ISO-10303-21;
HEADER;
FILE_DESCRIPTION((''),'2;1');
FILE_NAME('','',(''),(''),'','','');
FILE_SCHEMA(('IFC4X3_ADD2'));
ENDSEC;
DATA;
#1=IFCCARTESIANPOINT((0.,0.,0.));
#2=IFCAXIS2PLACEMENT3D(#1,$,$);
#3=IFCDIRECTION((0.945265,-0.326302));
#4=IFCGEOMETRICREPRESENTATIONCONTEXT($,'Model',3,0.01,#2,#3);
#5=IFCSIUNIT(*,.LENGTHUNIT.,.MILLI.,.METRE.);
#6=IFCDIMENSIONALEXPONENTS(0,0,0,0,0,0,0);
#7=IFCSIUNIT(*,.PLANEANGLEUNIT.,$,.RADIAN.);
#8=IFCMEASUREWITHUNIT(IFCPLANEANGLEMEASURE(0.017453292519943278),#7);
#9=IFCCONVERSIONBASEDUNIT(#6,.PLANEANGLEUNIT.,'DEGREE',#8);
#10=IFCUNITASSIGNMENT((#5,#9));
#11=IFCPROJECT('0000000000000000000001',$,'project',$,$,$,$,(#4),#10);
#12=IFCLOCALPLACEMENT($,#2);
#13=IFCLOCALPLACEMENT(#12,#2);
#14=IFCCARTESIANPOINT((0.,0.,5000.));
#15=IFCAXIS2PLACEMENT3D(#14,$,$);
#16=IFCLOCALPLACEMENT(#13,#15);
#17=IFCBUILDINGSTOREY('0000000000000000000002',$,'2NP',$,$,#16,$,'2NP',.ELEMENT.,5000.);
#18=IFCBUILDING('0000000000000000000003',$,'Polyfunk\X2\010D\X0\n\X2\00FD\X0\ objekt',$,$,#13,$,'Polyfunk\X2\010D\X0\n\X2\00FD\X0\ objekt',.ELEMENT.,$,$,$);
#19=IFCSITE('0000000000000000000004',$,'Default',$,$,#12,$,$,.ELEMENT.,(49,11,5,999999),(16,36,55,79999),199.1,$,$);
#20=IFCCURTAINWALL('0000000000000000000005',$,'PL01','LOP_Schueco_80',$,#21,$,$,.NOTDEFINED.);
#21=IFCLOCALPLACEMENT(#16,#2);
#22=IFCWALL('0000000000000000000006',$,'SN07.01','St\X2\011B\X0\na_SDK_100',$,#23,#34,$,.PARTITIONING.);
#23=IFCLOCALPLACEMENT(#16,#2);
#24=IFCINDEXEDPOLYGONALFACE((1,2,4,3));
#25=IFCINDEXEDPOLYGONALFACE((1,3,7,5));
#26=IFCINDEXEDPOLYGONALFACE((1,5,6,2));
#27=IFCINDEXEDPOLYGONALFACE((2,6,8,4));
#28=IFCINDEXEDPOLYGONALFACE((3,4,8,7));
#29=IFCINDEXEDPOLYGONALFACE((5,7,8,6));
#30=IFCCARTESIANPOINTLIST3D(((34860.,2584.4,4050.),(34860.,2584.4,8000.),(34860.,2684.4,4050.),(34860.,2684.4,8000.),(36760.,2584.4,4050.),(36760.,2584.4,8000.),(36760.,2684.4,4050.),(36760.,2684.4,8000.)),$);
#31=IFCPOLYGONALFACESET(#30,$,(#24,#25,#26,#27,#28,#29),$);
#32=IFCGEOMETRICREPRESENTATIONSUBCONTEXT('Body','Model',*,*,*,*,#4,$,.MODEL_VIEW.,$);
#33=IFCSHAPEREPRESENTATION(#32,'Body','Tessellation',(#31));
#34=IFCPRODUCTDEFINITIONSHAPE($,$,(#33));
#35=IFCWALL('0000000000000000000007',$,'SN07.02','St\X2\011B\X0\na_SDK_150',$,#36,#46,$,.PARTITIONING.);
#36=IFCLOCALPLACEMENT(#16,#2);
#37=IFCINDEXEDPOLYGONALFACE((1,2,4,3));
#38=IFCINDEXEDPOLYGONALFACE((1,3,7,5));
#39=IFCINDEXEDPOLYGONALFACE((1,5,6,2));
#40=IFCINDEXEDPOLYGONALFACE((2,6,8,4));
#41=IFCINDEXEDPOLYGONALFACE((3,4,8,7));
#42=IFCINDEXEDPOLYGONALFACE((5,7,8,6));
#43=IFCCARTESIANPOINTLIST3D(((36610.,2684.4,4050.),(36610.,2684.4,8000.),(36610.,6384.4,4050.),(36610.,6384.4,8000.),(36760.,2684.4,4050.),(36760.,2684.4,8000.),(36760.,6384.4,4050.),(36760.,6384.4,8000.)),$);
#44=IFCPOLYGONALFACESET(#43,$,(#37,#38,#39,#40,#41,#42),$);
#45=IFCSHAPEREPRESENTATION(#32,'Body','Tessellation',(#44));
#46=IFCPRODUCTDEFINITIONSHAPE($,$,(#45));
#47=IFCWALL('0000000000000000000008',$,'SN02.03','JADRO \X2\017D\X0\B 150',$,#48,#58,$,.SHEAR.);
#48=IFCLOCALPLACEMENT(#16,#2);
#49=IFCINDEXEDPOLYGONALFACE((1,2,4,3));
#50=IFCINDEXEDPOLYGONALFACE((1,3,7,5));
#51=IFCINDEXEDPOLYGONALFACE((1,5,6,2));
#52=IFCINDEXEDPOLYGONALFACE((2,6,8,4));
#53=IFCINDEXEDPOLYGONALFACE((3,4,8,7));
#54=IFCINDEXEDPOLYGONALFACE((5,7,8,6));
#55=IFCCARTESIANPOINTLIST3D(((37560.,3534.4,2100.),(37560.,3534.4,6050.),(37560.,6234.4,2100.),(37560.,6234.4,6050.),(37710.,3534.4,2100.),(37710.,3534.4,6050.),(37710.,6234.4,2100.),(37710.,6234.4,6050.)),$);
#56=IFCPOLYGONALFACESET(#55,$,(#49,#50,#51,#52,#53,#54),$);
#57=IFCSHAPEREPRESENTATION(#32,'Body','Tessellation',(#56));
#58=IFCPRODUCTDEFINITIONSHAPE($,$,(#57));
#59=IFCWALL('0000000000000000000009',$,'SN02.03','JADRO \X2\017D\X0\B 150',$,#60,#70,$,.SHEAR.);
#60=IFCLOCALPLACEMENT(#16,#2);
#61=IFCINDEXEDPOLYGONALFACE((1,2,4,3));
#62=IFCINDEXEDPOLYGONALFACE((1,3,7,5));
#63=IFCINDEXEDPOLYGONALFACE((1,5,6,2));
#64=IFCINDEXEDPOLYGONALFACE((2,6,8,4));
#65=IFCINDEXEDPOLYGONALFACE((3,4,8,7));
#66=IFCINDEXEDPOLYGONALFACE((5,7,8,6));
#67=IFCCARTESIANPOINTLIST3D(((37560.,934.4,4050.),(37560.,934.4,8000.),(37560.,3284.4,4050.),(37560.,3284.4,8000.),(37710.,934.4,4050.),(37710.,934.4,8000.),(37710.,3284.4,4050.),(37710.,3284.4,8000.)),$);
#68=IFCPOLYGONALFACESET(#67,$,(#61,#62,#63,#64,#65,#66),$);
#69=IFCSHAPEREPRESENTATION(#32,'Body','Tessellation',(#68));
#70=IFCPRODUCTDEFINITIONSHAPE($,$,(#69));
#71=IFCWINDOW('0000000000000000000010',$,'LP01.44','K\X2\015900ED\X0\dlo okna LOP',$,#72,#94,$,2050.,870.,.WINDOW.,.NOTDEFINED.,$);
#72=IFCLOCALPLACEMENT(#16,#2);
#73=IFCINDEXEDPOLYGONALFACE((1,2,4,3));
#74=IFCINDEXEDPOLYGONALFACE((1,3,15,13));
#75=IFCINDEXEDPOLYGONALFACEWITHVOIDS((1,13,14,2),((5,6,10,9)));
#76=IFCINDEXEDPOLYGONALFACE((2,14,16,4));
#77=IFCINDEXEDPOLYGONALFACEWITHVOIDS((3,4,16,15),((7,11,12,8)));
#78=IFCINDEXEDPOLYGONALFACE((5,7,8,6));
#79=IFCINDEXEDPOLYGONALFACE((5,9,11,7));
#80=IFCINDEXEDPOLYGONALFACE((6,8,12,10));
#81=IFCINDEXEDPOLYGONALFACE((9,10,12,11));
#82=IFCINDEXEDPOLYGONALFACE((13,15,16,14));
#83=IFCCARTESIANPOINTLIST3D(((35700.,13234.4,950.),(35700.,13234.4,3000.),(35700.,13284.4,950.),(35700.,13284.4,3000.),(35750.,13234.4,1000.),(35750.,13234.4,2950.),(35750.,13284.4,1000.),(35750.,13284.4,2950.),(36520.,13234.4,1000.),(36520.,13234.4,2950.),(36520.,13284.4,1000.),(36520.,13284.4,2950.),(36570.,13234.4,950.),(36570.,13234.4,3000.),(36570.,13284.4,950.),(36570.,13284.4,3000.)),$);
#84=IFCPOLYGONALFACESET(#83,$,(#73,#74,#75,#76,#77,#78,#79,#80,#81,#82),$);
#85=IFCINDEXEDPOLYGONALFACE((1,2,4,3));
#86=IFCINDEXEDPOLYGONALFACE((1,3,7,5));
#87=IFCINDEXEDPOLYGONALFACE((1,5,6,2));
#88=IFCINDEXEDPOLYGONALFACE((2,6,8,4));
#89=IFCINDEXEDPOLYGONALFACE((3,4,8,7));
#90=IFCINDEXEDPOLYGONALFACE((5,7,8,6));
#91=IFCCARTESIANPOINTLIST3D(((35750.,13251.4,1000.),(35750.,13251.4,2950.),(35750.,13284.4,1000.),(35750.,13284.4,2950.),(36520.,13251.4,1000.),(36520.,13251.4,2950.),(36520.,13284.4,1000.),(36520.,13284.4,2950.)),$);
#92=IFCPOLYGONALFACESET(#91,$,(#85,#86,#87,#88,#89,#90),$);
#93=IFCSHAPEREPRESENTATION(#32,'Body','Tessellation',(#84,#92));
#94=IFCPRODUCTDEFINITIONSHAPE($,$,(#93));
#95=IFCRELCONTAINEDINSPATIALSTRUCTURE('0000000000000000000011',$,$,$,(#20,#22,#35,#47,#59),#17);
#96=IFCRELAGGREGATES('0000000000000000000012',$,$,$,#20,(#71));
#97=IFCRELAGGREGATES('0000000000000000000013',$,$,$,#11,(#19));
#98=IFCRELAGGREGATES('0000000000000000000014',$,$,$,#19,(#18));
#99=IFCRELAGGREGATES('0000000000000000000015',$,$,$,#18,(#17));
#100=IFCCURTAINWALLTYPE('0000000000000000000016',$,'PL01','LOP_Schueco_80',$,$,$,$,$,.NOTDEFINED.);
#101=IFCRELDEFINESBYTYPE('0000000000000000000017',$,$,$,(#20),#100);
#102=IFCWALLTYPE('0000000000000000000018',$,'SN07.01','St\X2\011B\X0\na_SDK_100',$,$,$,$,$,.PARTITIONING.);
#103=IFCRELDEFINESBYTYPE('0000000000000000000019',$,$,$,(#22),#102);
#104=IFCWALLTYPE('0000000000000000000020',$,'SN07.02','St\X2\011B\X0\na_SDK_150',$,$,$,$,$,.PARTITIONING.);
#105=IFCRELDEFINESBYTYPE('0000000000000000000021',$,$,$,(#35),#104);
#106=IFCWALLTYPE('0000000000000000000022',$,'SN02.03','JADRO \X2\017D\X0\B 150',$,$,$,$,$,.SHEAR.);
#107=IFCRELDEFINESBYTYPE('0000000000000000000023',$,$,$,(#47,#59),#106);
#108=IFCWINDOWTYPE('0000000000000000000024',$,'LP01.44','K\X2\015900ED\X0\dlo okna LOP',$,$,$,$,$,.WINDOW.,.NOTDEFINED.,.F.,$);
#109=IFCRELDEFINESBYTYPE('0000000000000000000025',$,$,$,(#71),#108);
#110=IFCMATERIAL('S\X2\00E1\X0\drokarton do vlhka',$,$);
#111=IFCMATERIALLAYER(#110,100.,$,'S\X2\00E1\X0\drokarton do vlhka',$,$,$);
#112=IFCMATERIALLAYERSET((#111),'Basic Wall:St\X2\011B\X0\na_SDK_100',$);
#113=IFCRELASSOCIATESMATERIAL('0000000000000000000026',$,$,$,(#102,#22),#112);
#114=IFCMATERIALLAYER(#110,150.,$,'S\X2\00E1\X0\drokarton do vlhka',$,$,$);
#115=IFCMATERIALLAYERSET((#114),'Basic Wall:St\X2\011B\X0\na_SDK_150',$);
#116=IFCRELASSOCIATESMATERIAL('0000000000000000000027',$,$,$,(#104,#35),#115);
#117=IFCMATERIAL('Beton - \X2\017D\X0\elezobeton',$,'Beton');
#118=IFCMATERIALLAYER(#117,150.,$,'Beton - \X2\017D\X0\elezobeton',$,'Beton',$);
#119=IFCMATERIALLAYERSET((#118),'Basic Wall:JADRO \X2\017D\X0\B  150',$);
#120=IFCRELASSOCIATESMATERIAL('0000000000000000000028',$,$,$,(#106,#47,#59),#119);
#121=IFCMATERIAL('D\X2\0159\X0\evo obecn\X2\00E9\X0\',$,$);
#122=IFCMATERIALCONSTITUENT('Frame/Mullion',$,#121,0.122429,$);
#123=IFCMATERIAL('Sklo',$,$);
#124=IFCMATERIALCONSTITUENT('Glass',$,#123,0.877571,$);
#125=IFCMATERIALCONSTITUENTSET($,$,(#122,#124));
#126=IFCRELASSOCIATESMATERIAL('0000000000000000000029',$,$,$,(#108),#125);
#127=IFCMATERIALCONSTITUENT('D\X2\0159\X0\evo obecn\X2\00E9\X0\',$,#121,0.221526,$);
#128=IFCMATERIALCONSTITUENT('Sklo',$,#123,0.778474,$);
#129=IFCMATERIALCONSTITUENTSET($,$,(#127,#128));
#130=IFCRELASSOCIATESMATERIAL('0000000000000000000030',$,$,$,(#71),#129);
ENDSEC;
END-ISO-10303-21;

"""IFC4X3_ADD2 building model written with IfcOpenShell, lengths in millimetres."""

from ifc_helpers import new_model, entity, si_unit, converted_unit, direction, frame, frame_2d, origin, origin_2d_with_axis, place, context, subcontext, project, spatial, polyline, rectangle, outline, extrude, clip, bounded_halfspace, source, transform, mapped, material, layer, layer_set, constituent, constituent_set, type_object, type_shapes, element, aggregate, save


model = new_model("IFC4X3_ADD2")

# Units and contexts
model_context = context("Model", 3, precision=0.01, world=origin(), true_north=direction((0.945265, -0.326302)))
body_context = subcontext(model_context, "Body", "Model", "MODEL_VIEW")
ifc_project = project(units=[si_unit("LENGTHUNIT", "METRE", prefix="MILLI"), converted_unit("PLANEANGLEUNIT", "DEGREE", entity("IfcPlaneAngleMeasure", 0.017453292519943278), si_unit("PLANEANGLEUNIT", "RADIAN"), dimensions=[0, 0, 0, 0, 0, 0, 0])], contexts=[model_context])

# Site, building, storey
site_placement = place(None, origin())
site = spatial("IfcSite", under=ifc_project, at=site_placement, Name="Default", CompositionType="ELEMENT", RefLatitude=(49, 11, 5, 999999), RefLongitude=(16, 36, 55, 79999), RefElevation=199.1)
building_placement = place(site_placement, origin())
building = spatial("IfcBuilding", under=site, at=building_placement, Name="Polyfunkčný objekt", LongName="Polyfunkčný objekt", CompositionType="ELEMENT")
storey_placement = place(building_placement, frame((0.0, 0.0, 5000.0)))
storey = spatial("IfcBuildingStorey", under=building, at=storey_placement, Name="2NP", LongName="2NP", CompositionType="ELEMENT", Elevation=5000.0)

# Curtain wall
curtain_wall_type = type_object("IfcCurtainWallType", Name="PL01", Description="LOP_Schueco_80", PredefinedType="NOTDEFINED")
curtain_wall_placement = place(storey_placement, frame((0.0, 0.0, -5000.0)))
curtain_wall = element("IfcCurtainWall", 1, at=curtain_wall_placement, inside=storey, type_object=curtain_wall_type, Name="PL01", Description="LOP_Schueco_80", PredefinedType="NOTDEFINED")
ifc_material_1 = material(Name="Sklo")

# Walls
ifc_material_2 = material(Name="Sádrokarton do vlhka")
ifc_layer_1 = layer(ifc_material_2, 100.0, Name="Sádrokarton do vlhka")
ifc_layer_set_1 = layer_set([ifc_layer_1], Name="Basic Wall:Stěna_SDK_100")
wall_type_1 = type_object("IfcWallType", Name="SN07.01", Description="Stěna_SDK_100", PredefinedType="PARTITIONING", material=ifc_layer_set_1)
wall_1_placement = place(storey_placement, frame((34860.0, 2634.4, 4050.0)))
element("IfcWall", 2, at=wall_1_placement, inside=storey, type_object=wall_type_1, material=ifc_layer_set_1, Name="SN07.01", Description="Stěna_SDK_100", PredefinedType="PARTITIONING", context=body_context, shape_type="Clipping", body=[
    clip(clip(extrude(rectangle(XDim=1900.0, YDim=100.0, at=frame_2d((950.0, 0.0), x_axis=(-1.0, 0.0))), origin(), (0.0, 0.0, 1.0), 3950.0), bounded_halfspace(frame((1900.0, -50.0, 0.0), z_axis=(0.0, 0.0, 1.0), x_axis=(-1.0, 0.0, 0.0)), True, frame((1900.0, -50.0, 0.0)), polyline([(0.0, 0.0), (0.0, 100.0), (-150.0, 100.0), (-1900.0, 100.0), (-1900.0, 0.0), (-1800.0, 0.0), (0.0, 0.0)]))), bounded_halfspace(frame((0.0, -50.0, 3950.0), z_axis=(0.0, 0.0, -1.0), x_axis=(1.0, 0.0, 0.0)), True, frame((0.0, -50.0, 3950.0)), polyline([(0.0, 0.0), (100.0, 0.0), (1900.0, 0.0), (1900.0, 100.0), (1750.0, 100.0), (0.0, 100.0), (0.0, 0.0)]))),
])
ifc_layer_2 = layer(ifc_material_2, 150.0, Name="Sádrokarton do vlhka")
ifc_layer_set_2 = layer_set([ifc_layer_2], Name="Basic Wall:Stěna_SDK_150")
wall_type_2 = type_object("IfcWallType", Name="SN07.02", Description="Stěna_SDK_150", PredefinedType="PARTITIONING", material=ifc_layer_set_2)
wall_2_placement = place(storey_placement, frame((36685.0, 6384.4, 4050.0), z_axis=(0.0, 0.0, 1.0), x_axis=(0.0, -1.0, 0.0)))
element("IfcWall", 3, at=wall_2_placement, inside=storey, type_object=wall_type_2, material=ifc_layer_set_2, Name="SN07.02", Description="Stěna_SDK_150", PredefinedType="PARTITIONING", context=body_context, shape_type="SweptSolid", body=[
    extrude(rectangle(XDim=3700.0, YDim=150.0, at=frame_2d((1850.0, 0.0), x_axis=(-1.0, 0.0))), origin(), (0.0, 0.0, 1.0), 3950.0),
])

# Walls
ifc_material_3 = material(Name="Beton - Železobeton", Category="Beton")
ifc_layer_3 = layer(ifc_material_3, 150.0, Name="Beton - Železobeton", Category="Beton")
ifc_layer_set_3 = layer_set([ifc_layer_3], Name="Basic Wall:JADRO ŽB  150")
wall_type_3 = type_object("IfcWallType", Name="SN02.03", Description="JADRO ŽB 150", PredefinedType="SHEAR", material=ifc_layer_set_3)
wall_3_placement = place(storey_placement, frame((37635.0, 6234.4, 2100.0), z_axis=(0.0, 0.0, 1.0), x_axis=(0.0, -1.0, 0.0)))
element("IfcWall", 4, at=wall_3_placement, inside=storey, type_object=wall_type_3, material=ifc_layer_set_3, Name="SN02.03", Description="JADRO ŽB 150", PredefinedType="SHEAR", context=body_context, shape_type="SweptSolid", body=[
    extrude(rectangle(XDim=2700.0, YDim=150.0, at=frame_2d((1350.0, 0.0), x_axis=(-1.0, 0.0))), origin(), (0.0, 0.0, 1.0), 3950.0),
])
wall_4_placement = place(storey_placement, frame((37635.0, 3284.4, 4050.0), z_axis=(0.0, 0.0, 1.0), x_axis=(0.0, -1.0, 0.0)))
element("IfcWall", 5, at=wall_4_placement, inside=storey, type_object=wall_type_3, material=ifc_layer_set_3, Name="SN02.03", Description="JADRO ŽB 150", PredefinedType="SHEAR", context=body_context, shape_type="SweptSolid", body=[
    extrude(rectangle(XDim=2350.0, YDim=150.0, at=frame_2d((1175.0, 0.0), x_axis=(-1.0, 0.0))), origin(), (0.0, 0.0, 1.0), 3950.0),
])

# Window
ifc_material_4 = material(Name="Dřevo obecné")
ifc_constituent_1 = constituent(ifc_material_4, Name="Dřevo obecné", fraction=0.221526)
ifc_constituent_2 = constituent(ifc_material_1, Name="Sklo", fraction=0.778474)
ifc_constituent_set_1 = constituent_set(constituents=[ifc_constituent_1, ifc_constituent_2])
ifc_constituent_3 = constituent(ifc_material_4, Name="Frame/Mullion", fraction=0.122429)
ifc_constituent_4 = constituent(ifc_material_1, Name="Glass", fraction=0.877571)
ifc_constituent_set_2 = constituent_set(constituents=[ifc_constituent_3, ifc_constituent_4])
window_type = type_object("IfcWindowType", Name="LP01.44", Description="Křídlo okna LOP", ParameterTakesPrecedence=False, PartitioningType="NOTDEFINED", PredefinedType="WINDOW", material=ifc_constituent_set_2)
shared_shape_1 = source(origin(), body_context, "Body", "SweptSolid", [
    extrude(outline(polyline([(-1025.0, -435.0), (1025.0, -435.0), (1025.0, 435.0), (-1025.0, 435.0), (-1025.0, -435.0)]), holes=[polyline([(-975.0, -385.0), (-975.0, 385.0), (975.0, 385.0), (975.0, -385.0), (-975.0, -385.0)])]), frame((0.0, 0.0, 1025.0), z_axis=(0.0, 1.0, 0.0), x_axis=(0.0, 0.0, -1.0)), (0.0, 0.0, 1.0), 50.0),
    extrude(rectangle(XDim=33.0, YDim=770.0, at=origin_2d_with_axis()), frame((0.0, 33.5, 50.0), z_axis=(0.0, 0.0, 1.0), x_axis=(0.0, -1.0, 0.0)), (0.0, 0.0, 1.0), 1950.0),
])
type_shapes(window_type, [shared_shape_1])
window_placement = place(curtain_wall_placement, frame((36135.0, 13234.4, 5950.0)))
window = element("IfcWindow", 6, at=window_placement, type_object=window_type, material=ifc_constituent_set_1, Name="LP01.44", Description="Křídlo okna LOP", OverallHeight=2050.0, OverallWidth=870.0, PartitioningType="NOTDEFINED", PredefinedType="WINDOW", context=body_context, shape_type="MappedRepresentation", body=[
    mapped(shared_shape_1, transform((0.0, 0.0, 0.0), scale=1.0)),
])
aggregate(curtain_wall, [window])

save(model, "model.ifc")
